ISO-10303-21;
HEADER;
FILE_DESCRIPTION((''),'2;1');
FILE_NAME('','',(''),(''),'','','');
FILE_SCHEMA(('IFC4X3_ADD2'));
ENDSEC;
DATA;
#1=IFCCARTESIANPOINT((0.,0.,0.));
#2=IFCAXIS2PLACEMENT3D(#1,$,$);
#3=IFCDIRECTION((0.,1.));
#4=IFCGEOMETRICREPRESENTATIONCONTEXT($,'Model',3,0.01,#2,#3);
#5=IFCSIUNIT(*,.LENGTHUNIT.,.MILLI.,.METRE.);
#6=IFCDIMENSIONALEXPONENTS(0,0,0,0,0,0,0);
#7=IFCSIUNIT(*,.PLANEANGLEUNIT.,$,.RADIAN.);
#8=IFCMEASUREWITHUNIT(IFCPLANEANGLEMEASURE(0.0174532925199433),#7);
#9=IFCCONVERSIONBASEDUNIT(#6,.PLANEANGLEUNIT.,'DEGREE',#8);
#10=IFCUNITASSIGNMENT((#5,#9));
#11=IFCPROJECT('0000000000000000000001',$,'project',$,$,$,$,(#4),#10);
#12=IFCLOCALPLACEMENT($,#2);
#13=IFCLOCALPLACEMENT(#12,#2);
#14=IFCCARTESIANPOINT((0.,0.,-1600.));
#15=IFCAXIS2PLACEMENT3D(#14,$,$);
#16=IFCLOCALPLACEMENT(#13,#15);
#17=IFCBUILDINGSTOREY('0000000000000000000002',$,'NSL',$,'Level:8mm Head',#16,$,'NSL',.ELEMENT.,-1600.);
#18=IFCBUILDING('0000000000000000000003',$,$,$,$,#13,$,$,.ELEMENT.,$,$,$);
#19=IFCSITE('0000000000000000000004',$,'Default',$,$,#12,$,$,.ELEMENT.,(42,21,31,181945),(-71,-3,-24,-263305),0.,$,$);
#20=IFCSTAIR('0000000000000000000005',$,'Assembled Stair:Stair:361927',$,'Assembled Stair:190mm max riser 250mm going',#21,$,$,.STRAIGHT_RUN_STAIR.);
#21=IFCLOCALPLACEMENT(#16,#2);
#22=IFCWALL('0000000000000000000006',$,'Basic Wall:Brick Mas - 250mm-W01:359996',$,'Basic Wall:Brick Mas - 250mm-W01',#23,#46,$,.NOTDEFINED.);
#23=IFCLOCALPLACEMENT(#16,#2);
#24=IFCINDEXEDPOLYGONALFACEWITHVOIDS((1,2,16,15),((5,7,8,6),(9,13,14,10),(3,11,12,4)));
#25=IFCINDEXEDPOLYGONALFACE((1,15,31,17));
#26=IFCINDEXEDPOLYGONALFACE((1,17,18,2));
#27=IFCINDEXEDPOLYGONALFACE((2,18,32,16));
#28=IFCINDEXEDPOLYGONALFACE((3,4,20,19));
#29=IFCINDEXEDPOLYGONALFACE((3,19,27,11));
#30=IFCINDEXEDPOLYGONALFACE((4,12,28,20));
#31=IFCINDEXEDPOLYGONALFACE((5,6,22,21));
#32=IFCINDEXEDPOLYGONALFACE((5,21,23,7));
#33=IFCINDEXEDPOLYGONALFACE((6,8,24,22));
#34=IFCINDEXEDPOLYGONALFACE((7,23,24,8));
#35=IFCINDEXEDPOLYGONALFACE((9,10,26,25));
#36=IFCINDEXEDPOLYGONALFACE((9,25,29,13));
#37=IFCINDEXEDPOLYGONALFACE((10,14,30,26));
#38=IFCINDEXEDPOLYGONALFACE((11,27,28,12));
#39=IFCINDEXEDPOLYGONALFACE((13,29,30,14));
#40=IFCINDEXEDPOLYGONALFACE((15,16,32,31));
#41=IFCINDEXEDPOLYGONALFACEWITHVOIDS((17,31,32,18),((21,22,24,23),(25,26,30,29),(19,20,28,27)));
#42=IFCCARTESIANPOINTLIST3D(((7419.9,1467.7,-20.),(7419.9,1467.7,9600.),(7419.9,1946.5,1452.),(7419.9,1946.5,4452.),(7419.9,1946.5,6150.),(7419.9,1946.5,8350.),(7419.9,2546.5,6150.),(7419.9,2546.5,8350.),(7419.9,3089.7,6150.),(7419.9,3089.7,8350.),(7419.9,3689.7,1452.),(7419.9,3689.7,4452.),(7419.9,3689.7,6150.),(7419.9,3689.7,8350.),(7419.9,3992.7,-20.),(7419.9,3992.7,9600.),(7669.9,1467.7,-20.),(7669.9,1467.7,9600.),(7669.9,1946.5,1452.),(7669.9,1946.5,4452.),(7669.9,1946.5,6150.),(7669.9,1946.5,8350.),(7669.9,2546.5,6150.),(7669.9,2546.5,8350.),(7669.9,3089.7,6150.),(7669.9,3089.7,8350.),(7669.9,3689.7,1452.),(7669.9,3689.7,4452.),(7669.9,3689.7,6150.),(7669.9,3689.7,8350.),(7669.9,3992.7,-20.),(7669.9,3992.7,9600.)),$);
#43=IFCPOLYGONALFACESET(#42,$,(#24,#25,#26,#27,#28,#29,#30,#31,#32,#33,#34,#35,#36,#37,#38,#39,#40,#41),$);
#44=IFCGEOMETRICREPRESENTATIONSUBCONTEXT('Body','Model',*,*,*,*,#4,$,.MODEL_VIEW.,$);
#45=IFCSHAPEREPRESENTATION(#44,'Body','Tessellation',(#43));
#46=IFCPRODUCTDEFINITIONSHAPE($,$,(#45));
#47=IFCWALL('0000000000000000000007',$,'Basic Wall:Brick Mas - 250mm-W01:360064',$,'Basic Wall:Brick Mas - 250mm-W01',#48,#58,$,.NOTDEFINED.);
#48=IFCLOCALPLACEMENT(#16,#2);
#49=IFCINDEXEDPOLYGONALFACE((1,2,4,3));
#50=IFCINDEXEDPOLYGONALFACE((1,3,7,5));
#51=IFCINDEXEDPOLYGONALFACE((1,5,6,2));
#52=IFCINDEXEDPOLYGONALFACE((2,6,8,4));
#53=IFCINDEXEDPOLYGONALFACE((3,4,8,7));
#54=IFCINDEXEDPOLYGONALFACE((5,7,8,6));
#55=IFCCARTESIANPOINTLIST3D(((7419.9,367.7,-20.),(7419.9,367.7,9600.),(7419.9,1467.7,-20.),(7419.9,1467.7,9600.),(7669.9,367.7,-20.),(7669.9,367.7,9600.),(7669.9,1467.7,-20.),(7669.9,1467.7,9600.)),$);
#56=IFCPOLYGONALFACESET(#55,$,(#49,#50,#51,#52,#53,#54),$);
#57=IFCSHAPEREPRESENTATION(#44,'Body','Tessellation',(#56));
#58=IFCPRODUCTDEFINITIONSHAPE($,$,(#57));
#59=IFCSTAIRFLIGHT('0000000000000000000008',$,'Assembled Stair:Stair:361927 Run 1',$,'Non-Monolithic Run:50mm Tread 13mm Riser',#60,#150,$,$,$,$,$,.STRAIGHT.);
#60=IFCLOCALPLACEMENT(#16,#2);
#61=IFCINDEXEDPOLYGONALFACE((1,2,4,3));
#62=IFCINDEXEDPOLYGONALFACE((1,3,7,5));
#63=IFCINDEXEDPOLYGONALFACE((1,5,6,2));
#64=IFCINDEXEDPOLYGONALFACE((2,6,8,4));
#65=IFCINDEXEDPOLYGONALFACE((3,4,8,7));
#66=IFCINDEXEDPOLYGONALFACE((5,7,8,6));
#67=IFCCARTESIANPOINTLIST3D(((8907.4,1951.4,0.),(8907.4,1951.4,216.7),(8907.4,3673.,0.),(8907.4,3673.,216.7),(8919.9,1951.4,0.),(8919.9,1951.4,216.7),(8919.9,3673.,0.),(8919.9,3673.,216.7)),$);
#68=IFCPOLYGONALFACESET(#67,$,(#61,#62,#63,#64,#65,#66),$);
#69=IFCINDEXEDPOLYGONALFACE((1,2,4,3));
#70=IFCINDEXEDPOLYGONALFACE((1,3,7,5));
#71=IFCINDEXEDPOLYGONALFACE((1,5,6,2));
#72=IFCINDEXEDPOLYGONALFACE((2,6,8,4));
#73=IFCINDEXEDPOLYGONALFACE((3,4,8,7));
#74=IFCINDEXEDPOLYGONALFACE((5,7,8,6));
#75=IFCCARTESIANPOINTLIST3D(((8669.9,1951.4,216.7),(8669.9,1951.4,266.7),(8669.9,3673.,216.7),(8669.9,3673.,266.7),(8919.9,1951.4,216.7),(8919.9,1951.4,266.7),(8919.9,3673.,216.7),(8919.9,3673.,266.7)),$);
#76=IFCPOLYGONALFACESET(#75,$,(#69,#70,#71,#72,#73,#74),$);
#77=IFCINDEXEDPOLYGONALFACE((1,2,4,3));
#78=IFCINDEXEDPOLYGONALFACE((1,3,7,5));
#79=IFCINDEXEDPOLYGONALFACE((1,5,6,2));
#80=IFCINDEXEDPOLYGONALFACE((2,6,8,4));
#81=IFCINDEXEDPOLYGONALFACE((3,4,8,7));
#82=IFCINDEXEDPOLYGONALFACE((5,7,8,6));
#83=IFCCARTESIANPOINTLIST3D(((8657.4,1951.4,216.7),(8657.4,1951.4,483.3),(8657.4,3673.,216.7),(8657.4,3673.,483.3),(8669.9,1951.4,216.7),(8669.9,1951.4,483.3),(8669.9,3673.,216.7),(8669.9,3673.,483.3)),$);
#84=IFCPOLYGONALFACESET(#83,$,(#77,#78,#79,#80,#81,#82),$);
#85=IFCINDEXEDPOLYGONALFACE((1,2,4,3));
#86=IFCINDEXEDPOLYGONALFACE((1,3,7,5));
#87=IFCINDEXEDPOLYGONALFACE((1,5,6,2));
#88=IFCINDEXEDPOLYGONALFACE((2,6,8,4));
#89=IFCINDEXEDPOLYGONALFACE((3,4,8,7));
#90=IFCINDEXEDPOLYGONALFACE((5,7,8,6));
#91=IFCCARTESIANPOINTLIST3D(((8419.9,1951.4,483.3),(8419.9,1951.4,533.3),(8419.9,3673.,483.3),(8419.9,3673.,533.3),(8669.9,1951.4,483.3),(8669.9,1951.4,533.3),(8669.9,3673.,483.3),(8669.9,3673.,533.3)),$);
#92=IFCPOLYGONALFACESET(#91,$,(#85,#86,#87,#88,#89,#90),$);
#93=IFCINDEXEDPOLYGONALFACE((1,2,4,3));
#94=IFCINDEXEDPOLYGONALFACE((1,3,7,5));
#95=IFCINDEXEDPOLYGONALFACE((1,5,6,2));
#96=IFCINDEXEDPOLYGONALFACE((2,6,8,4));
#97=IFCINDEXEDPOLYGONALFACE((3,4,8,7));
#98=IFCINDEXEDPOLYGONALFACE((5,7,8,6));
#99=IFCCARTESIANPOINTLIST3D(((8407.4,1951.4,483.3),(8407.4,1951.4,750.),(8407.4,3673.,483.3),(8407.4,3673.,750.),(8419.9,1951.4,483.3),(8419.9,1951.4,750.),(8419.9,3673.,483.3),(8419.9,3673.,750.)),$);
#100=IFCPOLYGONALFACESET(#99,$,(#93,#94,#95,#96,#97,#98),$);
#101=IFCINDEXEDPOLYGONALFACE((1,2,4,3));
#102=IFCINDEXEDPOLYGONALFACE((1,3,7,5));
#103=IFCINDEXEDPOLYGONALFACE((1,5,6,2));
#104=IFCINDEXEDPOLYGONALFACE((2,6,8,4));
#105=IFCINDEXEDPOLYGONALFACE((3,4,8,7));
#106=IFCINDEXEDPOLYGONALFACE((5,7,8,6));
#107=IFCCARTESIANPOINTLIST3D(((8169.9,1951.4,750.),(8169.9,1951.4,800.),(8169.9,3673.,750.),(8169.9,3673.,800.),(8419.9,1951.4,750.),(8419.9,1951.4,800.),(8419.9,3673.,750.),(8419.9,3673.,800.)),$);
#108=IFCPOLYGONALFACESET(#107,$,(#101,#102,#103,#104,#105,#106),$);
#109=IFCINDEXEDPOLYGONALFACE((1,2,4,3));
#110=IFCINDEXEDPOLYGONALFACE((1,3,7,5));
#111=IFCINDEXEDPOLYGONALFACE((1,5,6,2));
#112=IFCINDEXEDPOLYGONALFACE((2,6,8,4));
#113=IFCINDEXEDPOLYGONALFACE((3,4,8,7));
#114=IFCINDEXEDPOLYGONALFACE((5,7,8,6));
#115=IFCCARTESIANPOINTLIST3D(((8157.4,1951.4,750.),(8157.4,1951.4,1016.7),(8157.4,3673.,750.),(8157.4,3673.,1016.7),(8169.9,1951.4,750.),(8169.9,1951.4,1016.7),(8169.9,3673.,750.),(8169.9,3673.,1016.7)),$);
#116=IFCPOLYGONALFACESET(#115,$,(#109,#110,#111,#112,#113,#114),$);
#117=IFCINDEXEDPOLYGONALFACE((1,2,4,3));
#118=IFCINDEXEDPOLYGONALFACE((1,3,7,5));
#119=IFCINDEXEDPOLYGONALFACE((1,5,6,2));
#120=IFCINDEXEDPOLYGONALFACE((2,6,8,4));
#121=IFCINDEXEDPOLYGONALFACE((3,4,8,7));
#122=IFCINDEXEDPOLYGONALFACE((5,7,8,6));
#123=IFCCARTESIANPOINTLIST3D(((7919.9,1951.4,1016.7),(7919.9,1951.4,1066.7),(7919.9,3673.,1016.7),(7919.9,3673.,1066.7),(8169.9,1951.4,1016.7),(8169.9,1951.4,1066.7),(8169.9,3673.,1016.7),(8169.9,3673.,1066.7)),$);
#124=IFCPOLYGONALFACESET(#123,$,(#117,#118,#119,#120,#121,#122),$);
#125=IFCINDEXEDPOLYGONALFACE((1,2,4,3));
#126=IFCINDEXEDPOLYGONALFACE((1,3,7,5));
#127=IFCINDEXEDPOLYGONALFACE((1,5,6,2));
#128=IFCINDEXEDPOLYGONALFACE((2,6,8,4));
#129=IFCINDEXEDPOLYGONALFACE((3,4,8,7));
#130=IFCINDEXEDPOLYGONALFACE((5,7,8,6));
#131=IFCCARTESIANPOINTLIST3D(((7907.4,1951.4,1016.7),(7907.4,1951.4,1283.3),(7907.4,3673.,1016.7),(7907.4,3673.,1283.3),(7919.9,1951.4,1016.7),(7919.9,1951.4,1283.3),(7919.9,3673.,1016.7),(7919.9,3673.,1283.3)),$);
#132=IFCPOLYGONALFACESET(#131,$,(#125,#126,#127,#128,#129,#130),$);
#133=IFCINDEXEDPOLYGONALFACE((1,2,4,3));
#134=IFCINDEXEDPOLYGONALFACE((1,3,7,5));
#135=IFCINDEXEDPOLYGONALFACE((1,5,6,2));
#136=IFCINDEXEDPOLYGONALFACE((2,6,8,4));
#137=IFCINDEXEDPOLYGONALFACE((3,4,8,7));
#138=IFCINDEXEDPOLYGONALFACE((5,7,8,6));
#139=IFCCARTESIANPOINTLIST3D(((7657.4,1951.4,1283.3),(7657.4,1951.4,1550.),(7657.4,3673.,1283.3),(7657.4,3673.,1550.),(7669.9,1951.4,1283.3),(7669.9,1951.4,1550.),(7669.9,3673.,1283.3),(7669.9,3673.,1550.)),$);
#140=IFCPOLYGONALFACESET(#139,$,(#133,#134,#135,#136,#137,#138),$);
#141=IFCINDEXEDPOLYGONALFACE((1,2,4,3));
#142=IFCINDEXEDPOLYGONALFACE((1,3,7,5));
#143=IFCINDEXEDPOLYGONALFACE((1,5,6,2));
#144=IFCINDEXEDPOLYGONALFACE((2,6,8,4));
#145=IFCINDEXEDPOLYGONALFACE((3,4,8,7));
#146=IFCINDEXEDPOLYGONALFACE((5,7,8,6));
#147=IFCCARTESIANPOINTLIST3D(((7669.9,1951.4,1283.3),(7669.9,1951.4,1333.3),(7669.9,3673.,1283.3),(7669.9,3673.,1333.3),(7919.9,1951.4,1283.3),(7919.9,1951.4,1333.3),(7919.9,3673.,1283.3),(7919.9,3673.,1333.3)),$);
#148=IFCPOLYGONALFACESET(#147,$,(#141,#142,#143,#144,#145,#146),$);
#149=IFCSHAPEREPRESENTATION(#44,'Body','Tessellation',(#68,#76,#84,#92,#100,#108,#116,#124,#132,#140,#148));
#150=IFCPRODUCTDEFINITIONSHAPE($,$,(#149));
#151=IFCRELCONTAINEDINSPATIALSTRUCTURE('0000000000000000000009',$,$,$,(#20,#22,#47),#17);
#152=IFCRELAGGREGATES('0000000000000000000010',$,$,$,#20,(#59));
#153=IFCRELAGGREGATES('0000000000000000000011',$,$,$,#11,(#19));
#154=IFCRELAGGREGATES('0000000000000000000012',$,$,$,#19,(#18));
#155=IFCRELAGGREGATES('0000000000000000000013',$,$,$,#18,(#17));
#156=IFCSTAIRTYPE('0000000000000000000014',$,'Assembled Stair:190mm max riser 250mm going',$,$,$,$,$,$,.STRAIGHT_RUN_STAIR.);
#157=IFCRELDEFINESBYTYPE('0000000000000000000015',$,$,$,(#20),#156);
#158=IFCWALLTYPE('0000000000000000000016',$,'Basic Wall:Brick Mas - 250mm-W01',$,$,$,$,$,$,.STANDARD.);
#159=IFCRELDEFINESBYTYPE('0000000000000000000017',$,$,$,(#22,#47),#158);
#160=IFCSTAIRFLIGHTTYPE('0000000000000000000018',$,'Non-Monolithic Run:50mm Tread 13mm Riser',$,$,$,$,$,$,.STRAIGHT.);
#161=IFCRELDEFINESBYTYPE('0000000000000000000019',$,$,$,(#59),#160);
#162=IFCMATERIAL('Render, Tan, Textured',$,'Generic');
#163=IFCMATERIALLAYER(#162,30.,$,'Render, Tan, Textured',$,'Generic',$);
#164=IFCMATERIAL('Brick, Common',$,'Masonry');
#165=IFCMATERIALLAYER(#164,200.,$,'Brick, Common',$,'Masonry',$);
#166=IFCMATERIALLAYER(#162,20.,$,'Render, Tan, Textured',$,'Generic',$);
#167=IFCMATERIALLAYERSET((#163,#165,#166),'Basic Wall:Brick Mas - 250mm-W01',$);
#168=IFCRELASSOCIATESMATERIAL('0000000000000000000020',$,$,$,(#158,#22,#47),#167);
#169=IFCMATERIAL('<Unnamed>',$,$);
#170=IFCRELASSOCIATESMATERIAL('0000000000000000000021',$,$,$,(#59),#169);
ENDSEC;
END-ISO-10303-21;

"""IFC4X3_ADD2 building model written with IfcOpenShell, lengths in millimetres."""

from ifc_helpers import new_model, entity, si_unit, converted_unit, direction, frame, frame_2d, origin, origin_2d_with_axis, place, context, subcontext, project, spatial, rectangle, extrude, material, layer, layer_set, type_object, element, aggregate, save


model = new_model("IFC4X3_ADD2")

# Units and contexts
model_context = context("Model", 3, precision=0.01, world=origin(), true_north=direction((0.0, 1.0)))
body_context = subcontext(model_context, "Body", "Model", "MODEL_VIEW")
ifc_project = project(units=[si_unit("LENGTHUNIT", "METRE", prefix="MILLI"), converted_unit("PLANEANGLEUNIT", "DEGREE", entity("IfcPlaneAngleMeasure", 0.0174532925199433), si_unit("PLANEANGLEUNIT", "RADIAN"), dimensions=[0, 0, 0, 0, 0, 0, 0])], contexts=[model_context])

# Site, building, storey
site_placement = place(None, origin())
site = spatial("IfcSite", under=ifc_project, at=site_placement, Name="Default", CompositionType="ELEMENT", RefLatitude=(42, 21, 31, 181945), RefLongitude=(-71, -3, -24, -263305), RefElevation=0.0)
building_placement = place(site_placement, origin())
building = spatial("IfcBuilding", under=site, at=building_placement, CompositionType="ELEMENT")
storey_placement = place(building_placement, frame((0.0, 0.0, -1600.0)))
storey = spatial("IfcBuildingStorey", under=building, at=storey_placement, Name="NSL", ObjectType="Level:8mm Head", LongName="NSL", CompositionType="ELEMENT", Elevation=-1600.0)

# Stair
stair_type = type_object("IfcStairType", Name="Assembled Stair:190mm max riser 250mm going", PredefinedType="STRAIGHT_RUN_STAIR")
stair_placement = place(storey_placement, origin())
stair = element("IfcStair", 1, at=stair_placement, inside=storey, type_object=stair_type, Name="Assembled Stair:Stair:361927", ObjectType="Assembled Stair:190mm max riser 250mm going", PredefinedType="STRAIGHT_RUN_STAIR")
ifc_material_1 = material(Name="<Unnamed>")

# Shared definitions
ifc_material_2 = material(Name="Render, Tan, Textured", Category="Generic")
ifc_layer_1 = layer(ifc_material_2, 30.0, Name="Render, Tan, Textured", Category="Generic")
ifc_material_3 = material(Name="Brick, Common", Category="Masonry")
ifc_layer_2 = layer(ifc_material_3, 200.0, Name="Brick, Common", Category="Masonry")
ifc_layer_3 = layer(ifc_material_2, 20.0, Name="Render, Tan, Textured", Category="Generic")
ifc_layer_set_1 = layer_set([ifc_layer_1, ifc_layer_2, ifc_layer_3], Name="Basic Wall:Brick Mas - 250mm-W01")
wall_type = type_object("IfcWallType", Name="Basic Wall:Brick Mas - 250mm-W01", PredefinedType="STANDARD", material=ifc_layer_set_1)

# Wall, openings
wall_1_placement = place(storey_placement, frame((7544.9, 3992.7, -20.0), z_axis=(0.0, 0.0, 1.0), x_axis=(0.0, -1.0, 0.0)))
wall_1 = element("IfcWall", 2, at=wall_1_placement, inside=storey, type_object=wall_type, material=ifc_layer_set_1, Name="Basic Wall:Brick Mas - 250mm-W01:359996", ObjectType="Basic Wall:Brick Mas - 250mm-W01", PredefinedType="NOTDEFINED", context=body_context, shape_type="SweptSolid", body=[
    extrude(rectangle(XDim=2525.0, YDim=250.0, at=frame_2d((1262.5, 0.0), x_axis=(-1.0, 0.0))), origin(), (0.0, 0.0, 1.0), 9620.0),
])
opening_1_placement = place(wall_1_placement, origin())
element("IfcOpeningElement", 3, at=opening_1_placement, cuts=wall_1, PredefinedType="OPENING", context=body_context, shape_type="SweptSolid", body=[
    extrude(rectangle(XDim=3000.0, YDim=1743.2, at=frame_2d((0.0, 0.0), x_axis=(1.0, 0.0))), frame((1174.6, 125.0, 2972.0), z_axis=(0.0, -1.0, 0.0), x_axis=(0.0, 0.0, -1.0)), (0.0, 0.0, 1.0), 250.0),
])
opening_2_placement = place(wall_1_placement, origin())
element("IfcOpeningElement", 4, at=opening_2_placement, cuts=wall_1, PredefinedType="OPENING", context=body_context, shape_type="SweptSolid", body=[
    extrude(rectangle(XDim=2200.0, YDim=600.0, at=frame_2d((0.0, 0.0), x_axis=(1.0, 0.0))), frame((1746.2, 125.0, 7270.0), z_axis=(0.0, -1.0, 0.0), x_axis=(0.0, 0.0, -1.0)), (0.0, 0.0, 1.0), 250.0),
])
opening_3_placement = place(wall_1_placement, origin())
element("IfcOpeningElement", 5, at=opening_3_placement, cuts=wall_1, PredefinedType="OPENING", context=body_context, shape_type="SweptSolid", body=[
    extrude(rectangle(XDim=2200.0, YDim=600.0, at=origin_2d_with_axis()), frame((603.0, 125.0, 7270.0), z_axis=(0.0, -1.0, 0.0), x_axis=(0.0, 0.0, -1.0)), (0.0, 0.0, 1.0), 250.0),
])

# Wall
wall_2_placement = place(storey_placement, frame((7544.9, 1467.7, -20.0), z_axis=(0.0, 0.0, 1.0), x_axis=(0.0, -1.0, 0.0)))
element("IfcWall", 6, at=wall_2_placement, inside=storey, type_object=wall_type, material=ifc_layer_set_1, Name="Basic Wall:Brick Mas - 250mm-W01:360064", ObjectType="Basic Wall:Brick Mas - 250mm-W01", PredefinedType="NOTDEFINED", context=body_context, shape_type="SweptSolid", body=[
    extrude(rectangle(XDim=1100.0, YDim=250.0, at=frame_2d((550.0, 0.0), x_axis=(-1.0, 0.0))), origin(), (0.0, 0.0, 1.0), 9620.0),
])

# Stair flight
stair_flight_type = type_object("IfcStairFlightType", Name="Non-Monolithic Run:50mm Tread 13mm Riser", PredefinedType="STRAIGHT")
stair_flight_placement = place(stair_placement, frame((7657.4, 1951.4, 0.0)))
stair_flight = element("IfcStairFlight", 7, at=stair_flight_placement, type_object=stair_flight_type, material=ifc_material_1, Name="Assembled Stair:Stair:361927 Run 1", ObjectType="Non-Monolithic Run:50mm Tread 13mm Riser", PredefinedType="STRAIGHT", context=body_context, shape_type="SweptSolid", body=[
    extrude(rectangle(XDim=1721.7, YDim=12.5, at=origin_2d_with_axis()), frame((1256.2, 860.8, 0.0), z_axis=(0.0, 0.0, 1.0), x_axis=(0.0, -1.0, 0.0)), (0.0, 0.0, 1.0), 216.7),
    extrude(rectangle(XDim=250.0, YDim=1721.7, at=frame_2d((0.0, 0.0), x_axis=(1.0, 0.0))), frame((1137.5, 860.8, 216.7)), (0.0, 0.0, 1.0), 50.0),
    extrude(rectangle(XDim=1721.7, YDim=12.5, at=frame_2d((0.0, 0.0), x_axis=(1.0, 0.0))), frame((1006.3, 860.8, 216.7), z_axis=(0.0, 0.0, 1.0), x_axis=(0.0, -1.0, 0.0)), (0.0, 0.0, 1.0), 266.7),
    extrude(rectangle(XDim=250.0, YDim=1721.7, at=frame_2d((0.0, 0.0), x_axis=(1.0, 0.0))), frame((887.5, 860.8, 483.3)), (0.0, 0.0, 1.0), 50.0),
    extrude(rectangle(XDim=1721.7, YDim=12.5, at=frame_2d((0.0, 0.0), x_axis=(1.0, 0.0))), frame((756.3, 860.8, 483.3), z_axis=(0.0, 0.0, 1.0), x_axis=(0.0, -1.0, 0.0)), (0.0, 0.0, 1.0), 266.7),
    extrude(rectangle(XDim=250.0, YDim=1721.7, at=frame_2d((0.0, 0.0), x_axis=(1.0, 0.0))), frame((637.5, 860.8, 750.0)), (0.0, 0.0, 1.0), 50.0),
    extrude(rectangle(XDim=1721.7, YDim=12.5, at=frame_2d((0.0, 0.0), x_axis=(1.0, 0.0))), frame((506.3, 860.8, 750.0), z_axis=(0.0, 0.0, 1.0), x_axis=(0.0, -1.0, 0.0)), (0.0, 0.0, 1.0), 266.7),
    extrude(rectangle(XDim=250.0, YDim=1721.7, at=origin_2d_with_axis()), frame((387.5, 860.8, 1016.7)), (0.0, 0.0, 1.0), 50.0),
    extrude(rectangle(XDim=1721.7, YDim=12.5, at=frame_2d((0.0, 0.0), x_axis=(1.0, 0.0))), frame((256.3, 860.8, 1016.7), z_axis=(0.0, 0.0, 1.0), x_axis=(0.0, -1.0, 0.0)), (0.0, 0.0, 1.0), 266.7),
    extrude(rectangle(XDim=1721.7, YDim=12.5, at=origin_2d_with_axis()), frame((6.3, 860.8, 1283.3), z_axis=(0.0, 0.0, 1.0), x_axis=(0.0, -1.0, 0.0)), (0.0, 0.0, 1.0), 266.7),
    extrude(rectangle(XDim=250.0, YDim=1721.7, at=frame_2d((0.0, 0.0), x_axis=(1.0, 0.0))), frame((137.5, 860.8, 1283.3)), (0.0, 0.0, 1.0), 50.0),
])
aggregate(stair, [stair_flight])

save(model, "model.ifc")
